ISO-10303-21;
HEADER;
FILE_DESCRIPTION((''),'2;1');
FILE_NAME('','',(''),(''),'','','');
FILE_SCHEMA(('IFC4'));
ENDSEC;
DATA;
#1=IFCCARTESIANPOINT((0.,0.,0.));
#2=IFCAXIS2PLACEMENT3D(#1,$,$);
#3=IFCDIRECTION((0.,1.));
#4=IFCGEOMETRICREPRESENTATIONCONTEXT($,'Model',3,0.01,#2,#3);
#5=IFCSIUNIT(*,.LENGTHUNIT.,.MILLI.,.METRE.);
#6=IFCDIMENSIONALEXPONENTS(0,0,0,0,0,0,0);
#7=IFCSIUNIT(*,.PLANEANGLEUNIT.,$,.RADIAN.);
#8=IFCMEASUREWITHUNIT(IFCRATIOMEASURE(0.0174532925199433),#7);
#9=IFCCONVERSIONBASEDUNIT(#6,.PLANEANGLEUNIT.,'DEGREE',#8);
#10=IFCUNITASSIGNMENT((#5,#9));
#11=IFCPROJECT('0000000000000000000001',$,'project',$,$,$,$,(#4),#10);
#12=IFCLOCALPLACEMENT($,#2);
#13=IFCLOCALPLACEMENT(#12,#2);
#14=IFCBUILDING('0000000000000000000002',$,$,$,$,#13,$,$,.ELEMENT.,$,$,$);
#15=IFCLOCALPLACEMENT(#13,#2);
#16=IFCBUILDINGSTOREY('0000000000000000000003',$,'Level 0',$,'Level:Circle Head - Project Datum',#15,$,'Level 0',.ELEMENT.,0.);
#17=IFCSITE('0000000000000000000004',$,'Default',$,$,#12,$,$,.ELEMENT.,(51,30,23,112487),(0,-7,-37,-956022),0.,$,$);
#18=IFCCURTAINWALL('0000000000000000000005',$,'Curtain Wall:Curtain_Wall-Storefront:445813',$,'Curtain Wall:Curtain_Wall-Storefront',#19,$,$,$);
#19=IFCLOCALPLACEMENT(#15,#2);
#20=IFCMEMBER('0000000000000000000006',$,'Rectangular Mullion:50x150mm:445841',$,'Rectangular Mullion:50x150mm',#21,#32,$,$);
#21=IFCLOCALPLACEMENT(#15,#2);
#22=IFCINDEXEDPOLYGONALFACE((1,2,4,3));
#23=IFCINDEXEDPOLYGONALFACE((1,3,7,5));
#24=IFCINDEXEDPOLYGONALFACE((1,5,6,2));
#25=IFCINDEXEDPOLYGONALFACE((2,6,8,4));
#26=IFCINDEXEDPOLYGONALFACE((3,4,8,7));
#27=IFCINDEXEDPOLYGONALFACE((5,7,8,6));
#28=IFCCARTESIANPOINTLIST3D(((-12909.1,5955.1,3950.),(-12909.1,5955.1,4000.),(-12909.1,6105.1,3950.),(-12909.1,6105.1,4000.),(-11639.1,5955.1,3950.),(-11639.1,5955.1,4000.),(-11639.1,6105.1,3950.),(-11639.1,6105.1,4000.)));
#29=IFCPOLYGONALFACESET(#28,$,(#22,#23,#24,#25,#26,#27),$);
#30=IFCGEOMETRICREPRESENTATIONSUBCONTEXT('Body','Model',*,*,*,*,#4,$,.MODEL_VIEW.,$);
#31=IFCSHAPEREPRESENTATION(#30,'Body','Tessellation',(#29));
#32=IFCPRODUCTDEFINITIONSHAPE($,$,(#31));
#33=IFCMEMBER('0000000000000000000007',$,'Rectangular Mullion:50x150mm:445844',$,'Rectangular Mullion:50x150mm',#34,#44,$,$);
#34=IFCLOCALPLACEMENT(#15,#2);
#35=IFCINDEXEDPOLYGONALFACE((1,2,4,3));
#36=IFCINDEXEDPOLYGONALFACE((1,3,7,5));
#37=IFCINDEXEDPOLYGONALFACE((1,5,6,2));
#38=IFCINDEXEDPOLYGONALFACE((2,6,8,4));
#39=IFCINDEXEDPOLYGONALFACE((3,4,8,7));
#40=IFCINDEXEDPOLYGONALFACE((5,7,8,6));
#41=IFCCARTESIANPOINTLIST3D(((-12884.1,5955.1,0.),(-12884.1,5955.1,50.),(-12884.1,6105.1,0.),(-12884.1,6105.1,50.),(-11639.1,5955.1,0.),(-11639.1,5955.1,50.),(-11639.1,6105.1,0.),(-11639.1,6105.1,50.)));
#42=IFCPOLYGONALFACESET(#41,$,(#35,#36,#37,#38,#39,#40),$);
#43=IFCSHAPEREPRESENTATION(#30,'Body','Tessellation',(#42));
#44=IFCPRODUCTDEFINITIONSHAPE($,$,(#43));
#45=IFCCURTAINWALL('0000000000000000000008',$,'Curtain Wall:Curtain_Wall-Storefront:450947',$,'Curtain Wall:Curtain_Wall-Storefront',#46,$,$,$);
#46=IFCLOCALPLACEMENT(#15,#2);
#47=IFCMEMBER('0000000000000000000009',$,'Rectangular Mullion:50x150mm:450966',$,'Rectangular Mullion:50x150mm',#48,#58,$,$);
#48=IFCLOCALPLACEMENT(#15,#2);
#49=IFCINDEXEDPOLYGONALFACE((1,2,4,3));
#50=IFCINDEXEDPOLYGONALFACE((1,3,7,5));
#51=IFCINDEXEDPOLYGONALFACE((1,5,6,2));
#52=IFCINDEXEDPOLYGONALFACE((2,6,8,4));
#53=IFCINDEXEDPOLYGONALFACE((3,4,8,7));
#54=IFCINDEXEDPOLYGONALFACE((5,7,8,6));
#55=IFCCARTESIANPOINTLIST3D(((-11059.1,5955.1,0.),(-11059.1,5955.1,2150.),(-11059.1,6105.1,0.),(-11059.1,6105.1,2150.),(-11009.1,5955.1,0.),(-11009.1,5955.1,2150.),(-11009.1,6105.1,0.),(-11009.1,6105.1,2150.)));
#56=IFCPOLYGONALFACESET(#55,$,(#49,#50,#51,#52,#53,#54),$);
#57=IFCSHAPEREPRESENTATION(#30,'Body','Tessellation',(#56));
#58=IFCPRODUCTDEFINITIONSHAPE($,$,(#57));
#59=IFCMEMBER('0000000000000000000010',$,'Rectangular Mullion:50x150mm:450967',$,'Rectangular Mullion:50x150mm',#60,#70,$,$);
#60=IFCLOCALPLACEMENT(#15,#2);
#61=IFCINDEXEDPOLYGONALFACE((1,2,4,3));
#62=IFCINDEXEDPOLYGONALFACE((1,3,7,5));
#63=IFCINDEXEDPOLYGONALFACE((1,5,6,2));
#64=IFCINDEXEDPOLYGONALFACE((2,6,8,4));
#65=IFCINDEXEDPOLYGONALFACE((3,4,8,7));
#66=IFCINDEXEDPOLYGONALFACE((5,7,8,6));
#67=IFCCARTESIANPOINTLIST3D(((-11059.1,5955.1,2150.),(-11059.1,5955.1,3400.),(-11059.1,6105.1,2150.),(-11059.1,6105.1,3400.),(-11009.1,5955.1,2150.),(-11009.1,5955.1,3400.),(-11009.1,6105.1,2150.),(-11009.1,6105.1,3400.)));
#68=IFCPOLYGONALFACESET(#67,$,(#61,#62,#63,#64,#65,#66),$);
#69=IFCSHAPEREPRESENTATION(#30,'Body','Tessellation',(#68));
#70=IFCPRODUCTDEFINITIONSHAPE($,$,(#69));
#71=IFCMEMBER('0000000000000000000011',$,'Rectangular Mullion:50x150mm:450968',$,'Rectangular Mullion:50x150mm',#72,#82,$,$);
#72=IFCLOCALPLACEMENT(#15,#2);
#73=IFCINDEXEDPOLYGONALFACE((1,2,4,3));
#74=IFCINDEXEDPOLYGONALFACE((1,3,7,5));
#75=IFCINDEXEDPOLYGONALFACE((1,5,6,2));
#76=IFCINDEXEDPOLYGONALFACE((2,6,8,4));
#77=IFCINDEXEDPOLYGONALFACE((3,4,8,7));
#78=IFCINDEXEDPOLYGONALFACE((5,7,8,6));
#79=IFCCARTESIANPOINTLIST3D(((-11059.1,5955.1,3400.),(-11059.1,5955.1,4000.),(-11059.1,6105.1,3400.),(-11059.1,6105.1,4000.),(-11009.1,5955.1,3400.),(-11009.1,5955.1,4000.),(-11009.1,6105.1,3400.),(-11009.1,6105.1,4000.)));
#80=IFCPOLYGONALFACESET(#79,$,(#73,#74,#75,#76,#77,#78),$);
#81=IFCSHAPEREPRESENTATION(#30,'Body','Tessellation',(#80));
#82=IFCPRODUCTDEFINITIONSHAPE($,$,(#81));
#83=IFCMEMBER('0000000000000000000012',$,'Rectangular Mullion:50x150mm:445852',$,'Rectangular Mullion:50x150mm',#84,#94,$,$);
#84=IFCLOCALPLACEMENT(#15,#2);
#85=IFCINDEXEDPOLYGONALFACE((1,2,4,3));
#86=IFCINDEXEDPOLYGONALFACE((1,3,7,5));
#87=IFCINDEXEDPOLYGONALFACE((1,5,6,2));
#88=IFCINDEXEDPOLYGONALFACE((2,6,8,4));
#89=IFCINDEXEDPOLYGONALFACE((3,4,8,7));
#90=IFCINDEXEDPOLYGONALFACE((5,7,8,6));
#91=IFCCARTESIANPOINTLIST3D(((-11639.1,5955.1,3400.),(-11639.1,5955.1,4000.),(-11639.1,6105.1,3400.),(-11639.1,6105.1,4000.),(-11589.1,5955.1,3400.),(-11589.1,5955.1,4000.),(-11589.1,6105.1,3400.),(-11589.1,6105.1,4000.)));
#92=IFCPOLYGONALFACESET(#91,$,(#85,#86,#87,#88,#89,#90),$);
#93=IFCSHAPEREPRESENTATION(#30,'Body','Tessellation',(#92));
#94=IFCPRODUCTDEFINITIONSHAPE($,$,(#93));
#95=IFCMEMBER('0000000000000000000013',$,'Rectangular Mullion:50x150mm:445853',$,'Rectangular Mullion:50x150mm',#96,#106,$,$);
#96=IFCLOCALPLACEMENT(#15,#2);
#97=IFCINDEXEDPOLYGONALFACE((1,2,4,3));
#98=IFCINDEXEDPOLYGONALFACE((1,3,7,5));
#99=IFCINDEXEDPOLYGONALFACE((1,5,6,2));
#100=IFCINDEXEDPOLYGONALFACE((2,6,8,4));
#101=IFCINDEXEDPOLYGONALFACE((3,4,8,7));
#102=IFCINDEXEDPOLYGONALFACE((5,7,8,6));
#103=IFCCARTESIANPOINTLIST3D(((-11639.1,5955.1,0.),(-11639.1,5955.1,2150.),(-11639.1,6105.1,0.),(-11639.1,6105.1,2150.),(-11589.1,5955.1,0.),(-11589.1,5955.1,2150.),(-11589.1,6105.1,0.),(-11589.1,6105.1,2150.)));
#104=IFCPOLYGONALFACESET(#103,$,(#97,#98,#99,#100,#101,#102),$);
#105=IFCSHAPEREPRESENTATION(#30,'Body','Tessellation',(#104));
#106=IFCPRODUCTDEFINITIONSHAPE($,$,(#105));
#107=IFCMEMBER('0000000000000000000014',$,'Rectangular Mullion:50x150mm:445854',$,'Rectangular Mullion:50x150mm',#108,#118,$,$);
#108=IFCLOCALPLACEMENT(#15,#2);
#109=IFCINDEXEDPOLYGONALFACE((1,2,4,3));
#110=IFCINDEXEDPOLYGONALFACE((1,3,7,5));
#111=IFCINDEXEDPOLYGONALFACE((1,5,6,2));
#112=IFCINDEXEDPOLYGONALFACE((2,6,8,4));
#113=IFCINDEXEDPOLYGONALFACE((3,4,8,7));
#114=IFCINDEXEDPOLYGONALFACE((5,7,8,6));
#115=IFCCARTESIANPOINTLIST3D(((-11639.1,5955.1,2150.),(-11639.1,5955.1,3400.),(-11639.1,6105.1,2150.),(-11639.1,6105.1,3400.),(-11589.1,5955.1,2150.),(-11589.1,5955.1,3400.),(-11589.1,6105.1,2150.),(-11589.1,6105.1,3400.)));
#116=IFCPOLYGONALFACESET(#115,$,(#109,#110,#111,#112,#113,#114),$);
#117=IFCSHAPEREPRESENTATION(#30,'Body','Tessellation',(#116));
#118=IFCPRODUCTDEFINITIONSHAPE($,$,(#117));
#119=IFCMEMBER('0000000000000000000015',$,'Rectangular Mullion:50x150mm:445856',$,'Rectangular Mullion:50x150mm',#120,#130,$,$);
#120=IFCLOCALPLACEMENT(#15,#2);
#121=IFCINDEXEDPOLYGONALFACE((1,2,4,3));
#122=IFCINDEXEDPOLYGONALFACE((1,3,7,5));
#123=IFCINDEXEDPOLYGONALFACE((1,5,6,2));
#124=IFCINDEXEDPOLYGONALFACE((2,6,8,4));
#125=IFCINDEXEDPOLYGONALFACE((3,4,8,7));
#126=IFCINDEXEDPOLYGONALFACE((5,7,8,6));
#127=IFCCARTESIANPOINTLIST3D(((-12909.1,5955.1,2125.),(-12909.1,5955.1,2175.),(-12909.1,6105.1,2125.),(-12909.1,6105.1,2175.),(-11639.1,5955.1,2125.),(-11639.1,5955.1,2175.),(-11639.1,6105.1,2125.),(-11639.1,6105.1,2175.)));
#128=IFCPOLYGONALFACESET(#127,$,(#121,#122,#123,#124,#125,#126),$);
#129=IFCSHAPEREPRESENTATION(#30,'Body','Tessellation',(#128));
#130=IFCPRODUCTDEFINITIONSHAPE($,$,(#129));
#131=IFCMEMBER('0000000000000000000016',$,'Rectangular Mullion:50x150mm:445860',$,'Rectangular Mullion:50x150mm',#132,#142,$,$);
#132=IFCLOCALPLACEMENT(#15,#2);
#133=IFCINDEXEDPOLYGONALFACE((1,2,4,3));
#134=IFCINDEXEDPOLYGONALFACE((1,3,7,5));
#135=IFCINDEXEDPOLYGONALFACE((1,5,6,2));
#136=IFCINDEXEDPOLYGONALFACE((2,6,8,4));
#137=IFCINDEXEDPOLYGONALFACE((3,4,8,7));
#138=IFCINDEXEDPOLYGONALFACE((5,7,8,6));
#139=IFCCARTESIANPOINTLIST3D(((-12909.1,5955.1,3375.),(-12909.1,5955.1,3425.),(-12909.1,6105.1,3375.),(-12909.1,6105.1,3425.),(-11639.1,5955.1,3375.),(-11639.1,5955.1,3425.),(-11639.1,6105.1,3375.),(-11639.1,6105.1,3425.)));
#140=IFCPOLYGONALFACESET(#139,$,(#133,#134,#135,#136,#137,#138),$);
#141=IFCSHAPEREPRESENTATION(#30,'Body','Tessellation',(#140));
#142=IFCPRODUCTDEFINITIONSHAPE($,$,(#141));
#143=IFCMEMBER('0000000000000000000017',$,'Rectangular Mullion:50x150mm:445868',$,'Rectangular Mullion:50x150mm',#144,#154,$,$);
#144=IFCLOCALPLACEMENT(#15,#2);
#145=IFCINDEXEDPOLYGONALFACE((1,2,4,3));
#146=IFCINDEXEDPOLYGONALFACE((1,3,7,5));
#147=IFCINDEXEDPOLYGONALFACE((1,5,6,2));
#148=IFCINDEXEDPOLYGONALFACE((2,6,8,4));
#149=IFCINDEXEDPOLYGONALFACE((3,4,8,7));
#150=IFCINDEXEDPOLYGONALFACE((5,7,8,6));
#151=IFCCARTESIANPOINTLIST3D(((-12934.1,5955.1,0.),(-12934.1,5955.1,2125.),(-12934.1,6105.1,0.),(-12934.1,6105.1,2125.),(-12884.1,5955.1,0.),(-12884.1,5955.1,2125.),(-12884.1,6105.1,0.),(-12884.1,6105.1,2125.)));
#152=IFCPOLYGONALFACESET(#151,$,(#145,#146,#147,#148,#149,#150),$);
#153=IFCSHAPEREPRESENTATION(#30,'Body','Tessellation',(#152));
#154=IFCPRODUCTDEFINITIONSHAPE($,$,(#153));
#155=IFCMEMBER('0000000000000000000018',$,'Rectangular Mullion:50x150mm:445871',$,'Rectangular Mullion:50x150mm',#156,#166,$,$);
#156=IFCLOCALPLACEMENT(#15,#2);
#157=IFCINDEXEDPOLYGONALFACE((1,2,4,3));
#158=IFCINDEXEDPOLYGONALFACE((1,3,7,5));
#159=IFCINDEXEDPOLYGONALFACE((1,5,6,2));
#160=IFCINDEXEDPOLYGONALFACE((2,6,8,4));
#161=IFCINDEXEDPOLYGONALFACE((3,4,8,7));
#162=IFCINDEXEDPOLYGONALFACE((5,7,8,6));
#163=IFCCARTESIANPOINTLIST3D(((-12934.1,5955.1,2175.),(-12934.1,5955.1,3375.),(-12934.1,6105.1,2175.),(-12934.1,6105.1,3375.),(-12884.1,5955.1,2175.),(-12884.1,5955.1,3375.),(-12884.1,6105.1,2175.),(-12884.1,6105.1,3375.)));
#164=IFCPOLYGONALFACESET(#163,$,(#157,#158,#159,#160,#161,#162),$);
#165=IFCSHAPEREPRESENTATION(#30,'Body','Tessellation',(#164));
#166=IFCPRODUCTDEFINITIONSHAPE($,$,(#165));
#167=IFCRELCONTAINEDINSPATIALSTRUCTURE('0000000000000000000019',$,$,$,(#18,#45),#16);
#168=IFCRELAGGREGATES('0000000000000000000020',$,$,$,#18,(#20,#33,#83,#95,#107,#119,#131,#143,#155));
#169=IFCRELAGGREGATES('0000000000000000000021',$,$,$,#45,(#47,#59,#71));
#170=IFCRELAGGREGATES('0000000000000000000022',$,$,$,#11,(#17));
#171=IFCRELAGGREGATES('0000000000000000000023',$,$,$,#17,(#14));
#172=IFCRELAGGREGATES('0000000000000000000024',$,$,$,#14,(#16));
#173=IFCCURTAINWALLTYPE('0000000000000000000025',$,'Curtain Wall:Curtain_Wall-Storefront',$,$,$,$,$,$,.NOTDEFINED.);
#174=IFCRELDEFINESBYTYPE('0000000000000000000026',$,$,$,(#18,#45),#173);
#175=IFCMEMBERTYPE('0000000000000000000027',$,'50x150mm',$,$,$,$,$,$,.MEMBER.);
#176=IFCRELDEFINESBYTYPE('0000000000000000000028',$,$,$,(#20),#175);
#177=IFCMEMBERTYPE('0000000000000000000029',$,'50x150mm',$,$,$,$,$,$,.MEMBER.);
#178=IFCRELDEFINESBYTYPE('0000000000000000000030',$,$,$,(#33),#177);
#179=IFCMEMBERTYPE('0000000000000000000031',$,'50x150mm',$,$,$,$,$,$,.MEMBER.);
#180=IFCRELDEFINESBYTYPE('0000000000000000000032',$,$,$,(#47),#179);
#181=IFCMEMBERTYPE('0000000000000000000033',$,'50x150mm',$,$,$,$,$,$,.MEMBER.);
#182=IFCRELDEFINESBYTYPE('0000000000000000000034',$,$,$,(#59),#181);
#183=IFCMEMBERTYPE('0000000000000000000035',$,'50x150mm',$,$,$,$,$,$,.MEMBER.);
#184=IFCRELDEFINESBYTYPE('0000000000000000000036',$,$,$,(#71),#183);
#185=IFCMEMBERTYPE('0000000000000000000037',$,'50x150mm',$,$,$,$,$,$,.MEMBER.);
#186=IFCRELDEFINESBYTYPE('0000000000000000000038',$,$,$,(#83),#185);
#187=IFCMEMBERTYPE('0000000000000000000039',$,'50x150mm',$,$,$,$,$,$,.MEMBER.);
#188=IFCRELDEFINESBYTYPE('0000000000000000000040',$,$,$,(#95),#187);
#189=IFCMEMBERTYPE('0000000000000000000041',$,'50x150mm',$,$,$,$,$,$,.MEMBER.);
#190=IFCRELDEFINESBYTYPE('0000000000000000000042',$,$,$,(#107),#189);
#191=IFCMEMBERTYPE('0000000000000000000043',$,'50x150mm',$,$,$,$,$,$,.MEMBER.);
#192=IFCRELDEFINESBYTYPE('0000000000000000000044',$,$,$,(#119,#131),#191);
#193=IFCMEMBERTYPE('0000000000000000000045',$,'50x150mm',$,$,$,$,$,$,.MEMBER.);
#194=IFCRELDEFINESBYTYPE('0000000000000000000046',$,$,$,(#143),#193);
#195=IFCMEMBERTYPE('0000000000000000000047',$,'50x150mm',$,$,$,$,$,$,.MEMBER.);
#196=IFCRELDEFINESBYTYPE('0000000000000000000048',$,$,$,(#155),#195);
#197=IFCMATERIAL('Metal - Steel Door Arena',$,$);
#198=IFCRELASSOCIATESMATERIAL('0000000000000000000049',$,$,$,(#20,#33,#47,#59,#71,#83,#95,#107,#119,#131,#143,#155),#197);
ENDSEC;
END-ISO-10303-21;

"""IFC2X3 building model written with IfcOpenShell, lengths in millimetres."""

from ifc_helpers import new_model, entity, si_unit, converted_unit, direction, frame, origin, origin_2d_with_axis, place, context, subcontext, project, spatial, rectangle, extrude, source, transform, mapped, material, type_object, type_shapes, element, aggregate, save


model = new_model("IFC2X3")

# Units and contexts
model_context = context("Model", 3, precision=0.01, world=origin(), true_north=direction((0.0, 1.0)))
body_context = subcontext(model_context, "Body", "Model", "MODEL_VIEW")
ifc_project = project(units=[si_unit("LENGTHUNIT", "METRE", prefix="MILLI"), converted_unit("PLANEANGLEUNIT", "DEGREE", entity("IfcRatioMeasure", 0.0174532925199433), si_unit("PLANEANGLEUNIT", "RADIAN"), dimensions=[0, 0, 0, 0, 0, 0, 0])], contexts=[model_context])

# Site, building, storey
site_placement = place(None, origin())
site = spatial("IfcSite", under=ifc_project, at=site_placement, Name="Default", CompositionType="ELEMENT", RefLatitude=(51, 30, 23, 112487), RefLongitude=(0, -7, -37, -956022), RefElevation=0.0)
building_placement = place(site_placement, origin())
building = spatial("IfcBuilding", under=site, at=building_placement, CompositionType="ELEMENT")
storey_placement = place(building_placement, origin())
storey = spatial("IfcBuildingStorey", under=building, at=storey_placement, Name="Level 0", ObjectType="Level:Circle Head - Project Datum", LongName="Level 0", CompositionType="ELEMENT", Elevation=0.0)

# Curtain walls, members
curtain_wall_type = type_object("IfcCurtainWallType", Name="Curtain Wall:Curtain_Wall-Storefront", PredefinedType="NOTDEFINED")
curtain_wall_1_placement = place(storey_placement, origin())
curtain_wall_1 = element("IfcCurtainWall", 1, at=curtain_wall_1_placement, inside=storey, type_object=curtain_wall_type, Name="Curtain Wall:Curtain_Wall-Storefront:445813", ObjectType="Curtain Wall:Curtain_Wall-Storefront")
ifc_material_1 = material(Name="Metal - Steel Door Arena")
member_type_1 = type_object("IfcMemberType", Name="50x150mm", PredefinedType="MEMBER")
shared_shape_1 = source(origin(), body_context, "Body", "SweptSolid", [
    extrude(rectangle(XDim=150.0, YDim=50.0, at=origin_2d_with_axis()), frame((-25.0, 0.0, -1270.0), z_axis=(0.0, 0.0, 1.0), x_axis=(0.0, -1.0, 0.0)), (0.0, 0.0, 1.0), 1270.0),
])
type_shapes(member_type_1, [shared_shape_1])
member_1_placement = place(storey_placement, frame((-12909.1, 6030.1, 4000.0), z_axis=(-1.0, 0.0, 0.0), x_axis=(0.0, 0.0, 1.0)))
member_1 = element("IfcMember", 2, at=member_1_placement, type_object=member_type_1, material=ifc_material_1, Name="Rectangular Mullion:50x150mm:445841", ObjectType="Rectangular Mullion:50x150mm", context=body_context, shape_type="MappedRepresentation", body=[
    mapped(shared_shape_1, transform((0.0, 0.0, 0.0), scale=1.0)),
])
member_type_2 = type_object("IfcMemberType", Name="50x150mm", PredefinedType="MEMBER")
shared_shape_2 = source(origin(), body_context, "Body", "SweptSolid", [
    extrude(rectangle(XDim=150.0, YDim=50.0, at=origin_2d_with_axis()), frame((-25.0, 0.0, -1245.0), z_axis=(0.0, 0.0, 1.0), x_axis=(0.0, -1.0, 0.0)), (0.0, 0.0, 1.0), 1245.0),
])
type_shapes(member_type_2, [shared_shape_2])
member_2_placement = place(storey_placement, frame((-11639.1, 6030.1, 0.0), z_axis=(1.0, 0.0, 0.0), x_axis=(0.0, 0.0, -1.0)))
member_2 = element("IfcMember", 3, at=member_2_placement, type_object=member_type_2, material=ifc_material_1, Name="Rectangular Mullion:50x150mm:445844", ObjectType="Rectangular Mullion:50x150mm", context=body_context, shape_type="MappedRepresentation", body=[
    mapped(shared_shape_2, transform((0.0, 0.0, 0.0), scale=1.0)),
])
curtain_wall_2_placement = place(storey_placement, origin())
curtain_wall_2 = element("IfcCurtainWall", 4, at=curtain_wall_2_placement, inside=storey, type_object=curtain_wall_type, Name="Curtain Wall:Curtain_Wall-Storefront:450947", ObjectType="Curtain Wall:Curtain_Wall-Storefront")
member_type_3 = type_object("IfcMemberType", Name="50x150mm", PredefinedType="MEMBER")
shared_shape_3 = source(origin(), body_context, "Body", "SweptSolid", [
    extrude(rectangle(XDim=150.0, YDim=50.0, at=origin_2d_with_axis()), frame((-25.0, 0.0, -2150.0), z_axis=(0.0, 0.0, 1.0), x_axis=(0.0, -1.0, 0.0)), (0.0, 0.0, 1.0), 2150.0),
])
type_shapes(member_type_3, [shared_shape_3])
member_3_placement = place(storey_placement, frame((-11059.1, 6030.1, 0.0), z_axis=(0.0, 0.0, -1.0), x_axis=(-1.0, 0.0, 0.0)))
member_3 = element("IfcMember", 5, at=member_3_placement, type_object=member_type_3, material=ifc_material_1, Name="Rectangular Mullion:50x150mm:450966", ObjectType="Rectangular Mullion:50x150mm", context=body_context, shape_type="MappedRepresentation", body=[
    mapped(shared_shape_3, transform((0.0, 0.0, 0.0), scale=1.0)),
])
member_type_4 = type_object("IfcMemberType", Name="50x150mm", PredefinedType="MEMBER")
shared_shape_4 = source(origin(), body_context, "Body", "SweptSolid", [
    extrude(rectangle(XDim=150.0, YDim=50.0, at=origin_2d_with_axis()), frame((-25.0, 0.0, -1250.0), z_axis=(0.0, 0.0, 1.0), x_axis=(0.0, -1.0, 0.0)), (0.0, 0.0, 1.0), 1250.0),
])
type_shapes(member_type_4, [shared_shape_4])
member_4_placement = place(storey_placement, frame((-11059.1, 6030.1, 2150.0), z_axis=(0.0, 0.0, -1.0), x_axis=(-1.0, 0.0, 0.0)))
member_4 = element("IfcMember", 6, at=member_4_placement, type_object=member_type_4, material=ifc_material_1, Name="Rectangular Mullion:50x150mm:450967", ObjectType="Rectangular Mullion:50x150mm", context=body_context, shape_type="MappedRepresentation", body=[
    mapped(shared_shape_4, transform((0.0, 0.0, 0.0), scale=1.0)),
])
member_type_5 = type_object("IfcMemberType", Name="50x150mm", PredefinedType="MEMBER")
shared_shape_5 = source(origin(), body_context, "Body", "SweptSolid", [
    extrude(rectangle(XDim=150.0, YDim=50.0, at=origin_2d_with_axis()), frame((-25.0, 0.0, -600.0), z_axis=(0.0, 0.0, 1.0), x_axis=(0.0, -1.0, 0.0)), (0.0, 0.0, 1.0), 600.0),
])
type_shapes(member_type_5, [shared_shape_5])
member_5_placement = place(storey_placement, frame((-11059.1, 6030.1, 3400.0), z_axis=(0.0, 0.0, -1.0), x_axis=(-1.0, 0.0, 0.0)))
member_5 = element("IfcMember", 7, at=member_5_placement, type_object=member_type_5, material=ifc_material_1, Name="Rectangular Mullion:50x150mm:450968", ObjectType="Rectangular Mullion:50x150mm", context=body_context, shape_type="MappedRepresentation", body=[
    mapped(shared_shape_5, transform((0.0, 0.0, 0.0), scale=1.0)),
])

# Members
member_type_6 = type_object("IfcMemberType", Name="50x150mm", PredefinedType="MEMBER")
shared_shape_6 = source(origin(), body_context, "Body", "SweptSolid", [
    extrude(rectangle(XDim=150.0, YDim=50.0, at=origin_2d_with_axis()), frame((-25.0, 0.0, -600.0), z_axis=(0.0, 0.0, 1.0), x_axis=(0.0, -1.0, 0.0)), (0.0, 0.0, 1.0), 600.0),
])
type_shapes(member_type_6, [shared_shape_6])
member_6_placement = place(storey_placement, frame((-11589.1, 6030.1, 4000.0)))
member_6 = element("IfcMember", 8, at=member_6_placement, type_object=member_type_6, material=ifc_material_1, Name="Rectangular Mullion:50x150mm:445852", ObjectType="Rectangular Mullion:50x150mm", context=body_context, shape_type="MappedRepresentation", body=[
    mapped(shared_shape_6, transform((0.0, 0.0, 0.0), scale=1.0)),
])
member_type_7 = type_object("IfcMemberType", Name="50x150mm", PredefinedType="MEMBER")
shared_shape_7 = source(origin(), body_context, "Body", "SweptSolid", [
    extrude(rectangle(XDim=150.0, YDim=50.0, at=origin_2d_with_axis()), frame((-25.0, 0.0, -2150.0), z_axis=(0.0, 0.0, 1.0), x_axis=(0.0, -1.0, 0.0)), (0.0, 0.0, 1.0), 2150.0),
])
type_shapes(member_type_7, [shared_shape_7])
member_7_placement = place(storey_placement, frame((-11589.1, 6030.1, 2150.0)))
member_7 = element("IfcMember", 9, at=member_7_placement, type_object=member_type_7, material=ifc_material_1, Name="Rectangular Mullion:50x150mm:445853", ObjectType="Rectangular Mullion:50x150mm", context=body_context, shape_type="MappedRepresentation", body=[
    mapped(shared_shape_7, transform((0.0, 0.0, 0.0), scale=1.0)),
])
member_type_8 = type_object("IfcMemberType", Name="50x150mm", PredefinedType="MEMBER")
shared_shape_8 = source(origin(), body_context, "Body", "SweptSolid", [
    extrude(rectangle(XDim=150.0, YDim=50.0, at=origin_2d_with_axis()), frame((-25.0, 0.0, -1250.0), z_axis=(0.0, 0.0, 1.0), x_axis=(0.0, -1.0, 0.0)), (0.0, 0.0, 1.0), 1250.0),
])
type_shapes(member_type_8, [shared_shape_8])
member_8_placement = place(storey_placement, frame((-11589.1, 6030.1, 3400.0)))
member_8 = element("IfcMember", 10, at=member_8_placement, type_object=member_type_8, material=ifc_material_1, Name="Rectangular Mullion:50x150mm:445854", ObjectType="Rectangular Mullion:50x150mm", context=body_context, shape_type="MappedRepresentation", body=[
    mapped(shared_shape_8, transform((0.0, 0.0, 0.0), scale=1.0)),
])
member_type_9 = type_object("IfcMemberType", Name="50x150mm", PredefinedType="MEMBER")
shared_shape_9 = source(origin(), body_context, "Body", "SweptSolid", [
    extrude(rectangle(XDim=150.0, YDim=50.0, at=origin_2d_with_axis()), frame((0.0, 0.0, -1270.0), z_axis=(0.0, 0.0, 1.0), x_axis=(0.0, -1.0, 0.0)), (0.0, 0.0, 1.0), 1270.0),
])
type_shapes(member_type_9, [shared_shape_9])
member_9_placement = place(storey_placement, frame((-12909.1, 6030.1, 2150.0), z_axis=(-1.0, 0.0, 0.0), x_axis=(0.0, 0.0, 1.0)))
member_9 = element("IfcMember", 11, at=member_9_placement, type_object=member_type_9, material=ifc_material_1, Name="Rectangular Mullion:50x150mm:445856", ObjectType="Rectangular Mullion:50x150mm", context=body_context, shape_type="MappedRepresentation", body=[
    mapped(shared_shape_9, transform((0.0, 0.0, 0.0), scale=1.0)),
])
member_10_placement = place(storey_placement, frame((-12909.1, 6030.1, 3400.0), z_axis=(-1.0, 0.0, 0.0), x_axis=(0.0, 0.0, 1.0)))
member_10 = element("IfcMember", 12, at=member_10_placement, type_object=member_type_9, material=ifc_material_1, Name="Rectangular Mullion:50x150mm:445860", ObjectType="Rectangular Mullion:50x150mm", context=body_context, shape_type="MappedRepresentation", body=[
    mapped(shared_shape_9, transform((0.0, 0.0, 0.0), scale=1.0)),
])
member_type_10 = type_object("IfcMemberType", Name="50x150mm", PredefinedType="MEMBER")
shared_shape_10 = source(origin(), body_context, "Body", "SweptSolid", [
    extrude(rectangle(XDim=150.0, YDim=50.0, at=origin_2d_with_axis()), frame((0.0, 0.0, -2125.0), z_axis=(0.0, 0.0, 1.0), x_axis=(0.0, -1.0, 0.0)), (0.0, 0.0, 1.0), 2125.0),
])
type_shapes(member_type_10, [shared_shape_10])
member_11_placement = place(storey_placement, frame((-12909.1, 6030.1, 0.0), z_axis=(0.0, 0.0, -1.0), x_axis=(-1.0, 0.0, 0.0)))
member_11 = element("IfcMember", 13, at=member_11_placement, type_object=member_type_10, material=ifc_material_1, Name="Rectangular Mullion:50x150mm:445868", ObjectType="Rectangular Mullion:50x150mm", context=body_context, shape_type="MappedRepresentation", body=[
    mapped(shared_shape_10, transform((0.0, 0.0, 0.0), scale=1.0)),
])
member_type_11 = type_object("IfcMemberType", Name="50x150mm", PredefinedType="MEMBER")
shared_shape_11 = source(origin(), body_context, "Body", "SweptSolid", [
    extrude(rectangle(XDim=150.0, YDim=50.0, at=origin_2d_with_axis()), frame((0.0, 0.0, -1200.0), z_axis=(0.0, 0.0, 1.0), x_axis=(0.0, -1.0, 0.0)), (0.0, 0.0, 1.0), 1200.0),
])
type_shapes(member_type_11, [shared_shape_11])
member_12_placement = place(storey_placement, frame((-12909.1, 6030.1, 2175.0), z_axis=(0.0, 0.0, -1.0), x_axis=(-1.0, 0.0, 0.0)))
member_12 = element("IfcMember", 14, at=member_12_placement, type_object=member_type_11, material=ifc_material_1, Name="Rectangular Mullion:50x150mm:445871", ObjectType="Rectangular Mullion:50x150mm", context=body_context, shape_type="MappedRepresentation", body=[
    mapped(shared_shape_11, transform((0.0, 0.0, 0.0), scale=1.0)),
])

aggregate(curtain_wall_1, [member_1, member_2, member_6, member_7, member_8, member_9, member_10, member_11, member_12])
aggregate(curtain_wall_2, [member_3, member_4, member_5])

save(model, "model.ifc")
